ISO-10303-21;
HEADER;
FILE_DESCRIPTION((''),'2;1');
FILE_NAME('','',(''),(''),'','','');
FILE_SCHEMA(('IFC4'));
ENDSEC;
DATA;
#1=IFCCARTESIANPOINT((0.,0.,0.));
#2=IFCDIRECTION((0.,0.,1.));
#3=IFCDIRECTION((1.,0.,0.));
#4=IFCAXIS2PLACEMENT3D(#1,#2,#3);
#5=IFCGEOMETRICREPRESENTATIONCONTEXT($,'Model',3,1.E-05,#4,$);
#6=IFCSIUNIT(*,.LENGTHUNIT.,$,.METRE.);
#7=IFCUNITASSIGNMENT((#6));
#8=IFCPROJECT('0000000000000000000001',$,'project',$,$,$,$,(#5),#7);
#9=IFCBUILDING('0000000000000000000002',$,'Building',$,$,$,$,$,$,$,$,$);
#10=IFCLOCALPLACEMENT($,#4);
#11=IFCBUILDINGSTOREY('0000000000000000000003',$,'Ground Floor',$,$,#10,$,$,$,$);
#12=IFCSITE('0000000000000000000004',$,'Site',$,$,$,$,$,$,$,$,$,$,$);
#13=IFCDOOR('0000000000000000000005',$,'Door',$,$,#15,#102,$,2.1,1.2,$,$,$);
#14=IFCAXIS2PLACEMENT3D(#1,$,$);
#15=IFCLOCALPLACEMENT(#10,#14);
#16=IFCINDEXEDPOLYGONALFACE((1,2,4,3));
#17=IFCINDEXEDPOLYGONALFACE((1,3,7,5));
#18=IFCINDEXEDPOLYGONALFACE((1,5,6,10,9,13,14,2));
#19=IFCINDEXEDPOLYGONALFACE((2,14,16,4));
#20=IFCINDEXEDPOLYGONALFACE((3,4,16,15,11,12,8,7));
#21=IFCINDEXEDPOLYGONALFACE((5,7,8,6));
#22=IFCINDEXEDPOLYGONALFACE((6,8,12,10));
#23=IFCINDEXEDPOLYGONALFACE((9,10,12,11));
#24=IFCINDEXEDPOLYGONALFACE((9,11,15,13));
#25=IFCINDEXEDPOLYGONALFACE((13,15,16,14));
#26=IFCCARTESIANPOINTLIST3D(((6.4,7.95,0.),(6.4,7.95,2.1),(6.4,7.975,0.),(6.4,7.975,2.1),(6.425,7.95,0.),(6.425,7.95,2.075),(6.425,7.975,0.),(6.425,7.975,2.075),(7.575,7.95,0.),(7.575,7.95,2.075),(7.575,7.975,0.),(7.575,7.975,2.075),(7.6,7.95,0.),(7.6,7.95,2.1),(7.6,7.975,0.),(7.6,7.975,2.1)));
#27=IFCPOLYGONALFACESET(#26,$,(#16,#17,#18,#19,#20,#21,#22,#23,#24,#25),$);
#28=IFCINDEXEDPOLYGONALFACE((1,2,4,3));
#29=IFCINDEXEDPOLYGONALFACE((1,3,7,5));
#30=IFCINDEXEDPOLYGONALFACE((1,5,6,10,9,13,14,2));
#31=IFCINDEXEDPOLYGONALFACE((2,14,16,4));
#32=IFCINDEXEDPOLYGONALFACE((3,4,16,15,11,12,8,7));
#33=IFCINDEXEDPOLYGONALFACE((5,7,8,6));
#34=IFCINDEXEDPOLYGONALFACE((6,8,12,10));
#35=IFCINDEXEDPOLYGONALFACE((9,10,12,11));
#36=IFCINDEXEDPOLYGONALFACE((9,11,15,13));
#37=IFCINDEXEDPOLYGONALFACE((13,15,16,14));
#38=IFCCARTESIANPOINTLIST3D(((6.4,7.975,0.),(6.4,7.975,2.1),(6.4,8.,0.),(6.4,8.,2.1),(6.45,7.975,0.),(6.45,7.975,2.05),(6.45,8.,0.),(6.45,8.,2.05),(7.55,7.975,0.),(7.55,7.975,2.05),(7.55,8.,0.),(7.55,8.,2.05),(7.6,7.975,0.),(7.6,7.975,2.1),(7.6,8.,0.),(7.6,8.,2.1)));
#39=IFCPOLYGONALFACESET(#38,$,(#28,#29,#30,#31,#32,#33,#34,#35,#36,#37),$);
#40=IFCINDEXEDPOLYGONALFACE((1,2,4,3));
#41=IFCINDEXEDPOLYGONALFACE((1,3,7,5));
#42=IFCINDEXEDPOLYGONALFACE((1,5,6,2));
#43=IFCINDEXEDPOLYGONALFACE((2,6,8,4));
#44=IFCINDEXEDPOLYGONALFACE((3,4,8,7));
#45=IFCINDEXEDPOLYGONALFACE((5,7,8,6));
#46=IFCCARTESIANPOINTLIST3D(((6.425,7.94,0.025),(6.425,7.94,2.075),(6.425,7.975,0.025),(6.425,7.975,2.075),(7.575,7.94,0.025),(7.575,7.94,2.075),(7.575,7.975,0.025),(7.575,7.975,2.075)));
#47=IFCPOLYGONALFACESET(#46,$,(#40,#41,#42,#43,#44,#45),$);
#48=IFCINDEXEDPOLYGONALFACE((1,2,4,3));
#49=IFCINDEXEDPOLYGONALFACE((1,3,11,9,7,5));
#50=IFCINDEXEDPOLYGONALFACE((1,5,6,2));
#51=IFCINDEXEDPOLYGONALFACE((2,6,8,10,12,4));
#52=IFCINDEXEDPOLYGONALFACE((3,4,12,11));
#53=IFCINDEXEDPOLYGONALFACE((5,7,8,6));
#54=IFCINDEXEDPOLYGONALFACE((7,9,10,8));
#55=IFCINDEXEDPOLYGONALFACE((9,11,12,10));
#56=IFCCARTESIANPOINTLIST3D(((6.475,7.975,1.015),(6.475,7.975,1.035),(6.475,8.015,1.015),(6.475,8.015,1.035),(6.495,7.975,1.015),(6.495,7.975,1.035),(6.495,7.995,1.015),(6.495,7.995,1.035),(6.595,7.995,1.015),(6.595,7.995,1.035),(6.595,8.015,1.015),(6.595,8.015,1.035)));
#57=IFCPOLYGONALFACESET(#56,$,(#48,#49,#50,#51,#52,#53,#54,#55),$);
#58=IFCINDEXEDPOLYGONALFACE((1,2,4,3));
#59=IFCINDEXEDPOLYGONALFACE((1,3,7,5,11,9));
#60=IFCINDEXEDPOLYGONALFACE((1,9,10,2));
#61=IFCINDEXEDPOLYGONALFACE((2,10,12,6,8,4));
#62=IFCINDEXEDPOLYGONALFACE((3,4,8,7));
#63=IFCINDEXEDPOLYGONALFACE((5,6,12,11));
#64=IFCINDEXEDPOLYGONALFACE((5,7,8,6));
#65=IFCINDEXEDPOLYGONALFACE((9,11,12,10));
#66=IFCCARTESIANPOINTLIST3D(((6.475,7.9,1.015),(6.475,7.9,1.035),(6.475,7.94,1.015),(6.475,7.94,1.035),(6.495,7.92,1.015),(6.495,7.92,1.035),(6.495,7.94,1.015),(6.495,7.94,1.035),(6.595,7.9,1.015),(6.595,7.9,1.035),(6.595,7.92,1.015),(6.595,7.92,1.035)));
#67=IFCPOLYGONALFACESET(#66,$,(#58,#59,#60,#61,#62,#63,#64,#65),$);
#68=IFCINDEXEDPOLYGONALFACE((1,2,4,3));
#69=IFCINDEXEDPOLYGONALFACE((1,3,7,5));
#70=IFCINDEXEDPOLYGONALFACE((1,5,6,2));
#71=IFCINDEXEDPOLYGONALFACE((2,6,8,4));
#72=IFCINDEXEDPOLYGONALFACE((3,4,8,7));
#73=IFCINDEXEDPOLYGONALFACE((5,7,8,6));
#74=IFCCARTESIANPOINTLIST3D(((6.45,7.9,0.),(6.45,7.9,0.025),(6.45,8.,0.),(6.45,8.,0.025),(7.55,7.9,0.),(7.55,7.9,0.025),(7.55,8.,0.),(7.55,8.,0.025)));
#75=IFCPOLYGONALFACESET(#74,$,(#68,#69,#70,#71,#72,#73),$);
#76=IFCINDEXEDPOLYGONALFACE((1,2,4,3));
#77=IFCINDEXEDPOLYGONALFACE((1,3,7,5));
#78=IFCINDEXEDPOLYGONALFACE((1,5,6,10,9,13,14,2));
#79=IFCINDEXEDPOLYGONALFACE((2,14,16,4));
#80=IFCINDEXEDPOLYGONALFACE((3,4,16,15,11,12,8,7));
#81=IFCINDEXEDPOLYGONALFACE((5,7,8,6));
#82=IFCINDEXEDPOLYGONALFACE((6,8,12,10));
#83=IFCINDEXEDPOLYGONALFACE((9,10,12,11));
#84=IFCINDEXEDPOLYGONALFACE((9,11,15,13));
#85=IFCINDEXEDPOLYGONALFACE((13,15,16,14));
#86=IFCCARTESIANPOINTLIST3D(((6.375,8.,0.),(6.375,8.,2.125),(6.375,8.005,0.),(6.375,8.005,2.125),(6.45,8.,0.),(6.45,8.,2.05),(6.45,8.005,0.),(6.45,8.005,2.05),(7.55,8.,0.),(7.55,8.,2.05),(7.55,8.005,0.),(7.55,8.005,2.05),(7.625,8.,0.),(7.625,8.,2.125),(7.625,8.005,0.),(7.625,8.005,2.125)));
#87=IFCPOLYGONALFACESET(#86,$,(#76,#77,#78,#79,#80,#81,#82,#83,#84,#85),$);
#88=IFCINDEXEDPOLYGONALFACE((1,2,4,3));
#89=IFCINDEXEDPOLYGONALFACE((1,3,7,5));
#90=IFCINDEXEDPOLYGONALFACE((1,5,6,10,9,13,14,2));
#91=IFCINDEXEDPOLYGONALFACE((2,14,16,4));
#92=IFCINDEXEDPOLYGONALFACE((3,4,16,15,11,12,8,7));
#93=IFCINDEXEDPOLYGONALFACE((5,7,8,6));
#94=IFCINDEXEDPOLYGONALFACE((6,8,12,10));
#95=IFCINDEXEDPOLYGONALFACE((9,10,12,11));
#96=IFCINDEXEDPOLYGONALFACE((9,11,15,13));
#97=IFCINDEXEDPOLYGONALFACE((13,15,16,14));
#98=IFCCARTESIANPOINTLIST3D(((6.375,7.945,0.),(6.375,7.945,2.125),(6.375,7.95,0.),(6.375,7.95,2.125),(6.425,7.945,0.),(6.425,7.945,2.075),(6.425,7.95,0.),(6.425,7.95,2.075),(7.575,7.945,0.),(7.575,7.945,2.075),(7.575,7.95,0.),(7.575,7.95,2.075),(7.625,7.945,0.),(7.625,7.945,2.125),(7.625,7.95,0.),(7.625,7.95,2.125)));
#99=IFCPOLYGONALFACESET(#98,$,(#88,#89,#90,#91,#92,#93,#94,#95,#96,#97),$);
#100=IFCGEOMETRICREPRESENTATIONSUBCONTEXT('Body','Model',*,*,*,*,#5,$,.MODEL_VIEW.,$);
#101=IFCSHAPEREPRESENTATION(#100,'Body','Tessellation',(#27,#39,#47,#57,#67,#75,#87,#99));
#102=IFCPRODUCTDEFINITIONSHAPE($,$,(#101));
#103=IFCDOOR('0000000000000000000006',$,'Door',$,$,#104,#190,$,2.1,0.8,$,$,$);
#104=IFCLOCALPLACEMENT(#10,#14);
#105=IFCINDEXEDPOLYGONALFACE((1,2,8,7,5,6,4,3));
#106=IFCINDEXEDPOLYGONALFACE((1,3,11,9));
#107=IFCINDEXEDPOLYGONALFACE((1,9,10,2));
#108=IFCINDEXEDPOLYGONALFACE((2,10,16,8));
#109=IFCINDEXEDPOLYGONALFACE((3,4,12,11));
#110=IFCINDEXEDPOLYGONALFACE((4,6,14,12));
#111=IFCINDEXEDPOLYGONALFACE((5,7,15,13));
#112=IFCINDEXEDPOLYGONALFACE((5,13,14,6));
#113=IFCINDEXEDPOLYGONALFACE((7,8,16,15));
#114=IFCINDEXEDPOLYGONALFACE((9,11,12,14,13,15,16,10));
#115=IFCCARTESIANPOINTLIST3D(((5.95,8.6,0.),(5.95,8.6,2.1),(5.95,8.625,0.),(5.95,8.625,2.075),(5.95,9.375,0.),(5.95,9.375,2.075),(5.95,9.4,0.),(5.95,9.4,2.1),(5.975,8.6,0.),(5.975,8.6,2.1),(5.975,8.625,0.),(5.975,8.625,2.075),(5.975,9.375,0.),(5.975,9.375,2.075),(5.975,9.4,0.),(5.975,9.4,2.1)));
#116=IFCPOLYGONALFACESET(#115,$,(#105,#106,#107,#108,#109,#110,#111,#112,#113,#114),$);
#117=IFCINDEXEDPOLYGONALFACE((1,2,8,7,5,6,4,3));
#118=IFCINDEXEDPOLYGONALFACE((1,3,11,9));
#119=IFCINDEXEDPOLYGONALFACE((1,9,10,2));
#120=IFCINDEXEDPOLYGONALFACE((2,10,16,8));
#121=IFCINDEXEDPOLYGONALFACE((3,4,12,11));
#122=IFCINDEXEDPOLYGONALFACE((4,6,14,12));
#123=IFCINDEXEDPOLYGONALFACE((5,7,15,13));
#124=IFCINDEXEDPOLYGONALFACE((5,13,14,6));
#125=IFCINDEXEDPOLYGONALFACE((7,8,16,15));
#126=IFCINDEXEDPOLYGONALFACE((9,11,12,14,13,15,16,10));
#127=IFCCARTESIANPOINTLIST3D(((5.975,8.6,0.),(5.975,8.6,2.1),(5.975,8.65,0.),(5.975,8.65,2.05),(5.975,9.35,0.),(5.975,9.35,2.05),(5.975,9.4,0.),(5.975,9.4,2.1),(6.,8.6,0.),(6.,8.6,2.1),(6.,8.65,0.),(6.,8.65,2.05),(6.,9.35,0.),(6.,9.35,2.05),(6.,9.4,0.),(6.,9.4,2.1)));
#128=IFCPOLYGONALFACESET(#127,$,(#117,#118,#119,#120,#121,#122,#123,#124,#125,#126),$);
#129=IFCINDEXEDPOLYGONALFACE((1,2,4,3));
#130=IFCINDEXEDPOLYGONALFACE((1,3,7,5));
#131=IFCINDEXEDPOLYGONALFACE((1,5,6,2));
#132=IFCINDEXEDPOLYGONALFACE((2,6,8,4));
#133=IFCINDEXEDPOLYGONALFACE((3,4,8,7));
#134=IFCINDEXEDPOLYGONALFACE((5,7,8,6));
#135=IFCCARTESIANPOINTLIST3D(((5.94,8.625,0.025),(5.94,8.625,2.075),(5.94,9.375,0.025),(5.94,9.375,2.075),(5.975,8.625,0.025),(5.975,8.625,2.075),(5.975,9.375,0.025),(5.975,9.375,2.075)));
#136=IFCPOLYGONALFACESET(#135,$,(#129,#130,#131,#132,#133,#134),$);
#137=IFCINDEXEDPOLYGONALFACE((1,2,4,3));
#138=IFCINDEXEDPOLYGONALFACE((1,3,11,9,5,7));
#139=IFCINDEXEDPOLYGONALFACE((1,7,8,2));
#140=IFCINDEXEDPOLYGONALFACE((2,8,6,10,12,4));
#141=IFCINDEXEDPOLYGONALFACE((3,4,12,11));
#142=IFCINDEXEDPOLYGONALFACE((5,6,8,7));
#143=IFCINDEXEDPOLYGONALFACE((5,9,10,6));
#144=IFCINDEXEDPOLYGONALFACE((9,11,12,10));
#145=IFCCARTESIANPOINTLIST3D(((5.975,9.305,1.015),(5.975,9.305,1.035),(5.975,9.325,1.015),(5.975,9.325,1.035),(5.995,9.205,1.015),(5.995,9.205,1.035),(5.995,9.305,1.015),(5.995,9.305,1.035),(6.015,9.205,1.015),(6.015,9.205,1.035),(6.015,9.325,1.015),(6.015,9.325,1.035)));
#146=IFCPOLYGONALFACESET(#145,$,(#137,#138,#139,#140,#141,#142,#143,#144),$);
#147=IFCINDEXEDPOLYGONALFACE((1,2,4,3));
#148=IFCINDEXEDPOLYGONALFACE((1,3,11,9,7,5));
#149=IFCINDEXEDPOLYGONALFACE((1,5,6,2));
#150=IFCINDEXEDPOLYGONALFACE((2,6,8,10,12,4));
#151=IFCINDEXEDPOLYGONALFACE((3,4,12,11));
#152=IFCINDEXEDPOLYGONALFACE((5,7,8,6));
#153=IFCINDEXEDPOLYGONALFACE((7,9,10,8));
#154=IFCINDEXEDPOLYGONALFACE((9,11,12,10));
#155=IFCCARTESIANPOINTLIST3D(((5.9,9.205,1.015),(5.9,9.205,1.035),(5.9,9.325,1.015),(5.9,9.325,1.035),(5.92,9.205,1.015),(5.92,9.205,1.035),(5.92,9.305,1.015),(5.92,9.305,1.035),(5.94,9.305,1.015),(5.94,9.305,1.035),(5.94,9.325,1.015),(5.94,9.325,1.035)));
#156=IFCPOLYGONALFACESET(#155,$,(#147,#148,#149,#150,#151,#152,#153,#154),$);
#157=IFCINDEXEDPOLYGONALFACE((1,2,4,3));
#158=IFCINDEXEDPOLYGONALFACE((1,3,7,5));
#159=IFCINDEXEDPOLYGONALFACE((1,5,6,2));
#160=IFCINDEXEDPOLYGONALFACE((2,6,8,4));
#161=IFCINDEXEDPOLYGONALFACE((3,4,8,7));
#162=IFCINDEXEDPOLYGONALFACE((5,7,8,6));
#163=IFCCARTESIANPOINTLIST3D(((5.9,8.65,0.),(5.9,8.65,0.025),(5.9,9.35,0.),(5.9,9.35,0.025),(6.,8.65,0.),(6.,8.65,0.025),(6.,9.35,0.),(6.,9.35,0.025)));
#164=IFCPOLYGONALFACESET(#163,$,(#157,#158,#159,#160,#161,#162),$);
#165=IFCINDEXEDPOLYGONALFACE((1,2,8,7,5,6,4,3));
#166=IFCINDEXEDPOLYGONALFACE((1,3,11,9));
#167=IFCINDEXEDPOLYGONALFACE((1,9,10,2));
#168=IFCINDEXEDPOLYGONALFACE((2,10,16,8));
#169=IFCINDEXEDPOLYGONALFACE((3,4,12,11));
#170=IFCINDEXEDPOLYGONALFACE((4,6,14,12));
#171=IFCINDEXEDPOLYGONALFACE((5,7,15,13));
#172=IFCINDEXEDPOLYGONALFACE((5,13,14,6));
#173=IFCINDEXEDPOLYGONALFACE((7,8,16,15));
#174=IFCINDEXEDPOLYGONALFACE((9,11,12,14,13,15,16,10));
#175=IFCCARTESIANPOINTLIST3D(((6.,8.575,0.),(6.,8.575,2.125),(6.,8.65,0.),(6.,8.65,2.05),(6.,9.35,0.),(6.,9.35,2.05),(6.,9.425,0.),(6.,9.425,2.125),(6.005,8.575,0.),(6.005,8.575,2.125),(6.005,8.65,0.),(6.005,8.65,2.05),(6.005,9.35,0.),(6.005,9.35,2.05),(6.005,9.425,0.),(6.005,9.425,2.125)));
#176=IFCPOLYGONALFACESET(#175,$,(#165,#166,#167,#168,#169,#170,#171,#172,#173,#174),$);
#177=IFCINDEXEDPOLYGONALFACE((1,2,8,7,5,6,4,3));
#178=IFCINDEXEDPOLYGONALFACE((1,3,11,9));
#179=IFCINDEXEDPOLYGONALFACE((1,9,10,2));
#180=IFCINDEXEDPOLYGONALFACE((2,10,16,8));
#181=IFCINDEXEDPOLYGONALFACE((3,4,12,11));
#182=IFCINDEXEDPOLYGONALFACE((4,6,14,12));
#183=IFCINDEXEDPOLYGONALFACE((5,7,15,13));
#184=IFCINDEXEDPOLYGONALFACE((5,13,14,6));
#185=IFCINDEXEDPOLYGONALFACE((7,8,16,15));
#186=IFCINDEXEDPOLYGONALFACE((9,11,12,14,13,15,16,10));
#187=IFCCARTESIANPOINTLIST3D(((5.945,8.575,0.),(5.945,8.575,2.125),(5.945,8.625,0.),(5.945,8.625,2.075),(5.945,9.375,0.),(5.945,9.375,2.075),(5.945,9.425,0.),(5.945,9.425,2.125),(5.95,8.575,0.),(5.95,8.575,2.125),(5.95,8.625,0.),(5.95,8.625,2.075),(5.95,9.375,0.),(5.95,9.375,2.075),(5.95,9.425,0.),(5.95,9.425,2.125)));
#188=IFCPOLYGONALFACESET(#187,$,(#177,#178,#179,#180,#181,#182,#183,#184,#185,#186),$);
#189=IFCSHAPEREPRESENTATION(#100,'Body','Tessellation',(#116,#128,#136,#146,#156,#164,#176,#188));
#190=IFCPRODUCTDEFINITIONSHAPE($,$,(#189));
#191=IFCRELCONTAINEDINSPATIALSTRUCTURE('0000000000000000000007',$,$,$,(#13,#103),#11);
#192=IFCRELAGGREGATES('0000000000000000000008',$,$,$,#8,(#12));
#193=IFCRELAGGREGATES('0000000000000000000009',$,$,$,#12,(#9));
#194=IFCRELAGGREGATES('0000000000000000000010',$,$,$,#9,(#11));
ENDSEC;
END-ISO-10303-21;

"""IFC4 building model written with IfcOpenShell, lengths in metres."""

from ifc_helpers import new_model, si_unit, frame, origin_with_axes, place, context, subcontext, project, spatial, line, indexed_curve, outline, extrude, element, save


model = new_model("IFC4")

# Units and contexts
model_context = context("Model", 3, precision=1e-05, world=origin_with_axes())
body_context = subcontext(model_context, "Body", "Model", "MODEL_VIEW")
ifc_project = project(units=[si_unit("LENGTHUNIT", "METRE")], contexts=[model_context])

# Site, building, storey
site = spatial("IfcSite", under=ifc_project, Name="Site")
building = spatial("IfcBuilding", under=site, Name="Building")
storey_placement = place(None, origin_with_axes())
storey = spatial("IfcBuildingStorey", under=building, at=storey_placement, Name="Ground Floor")

# Doors
door_1_placement = place(storey_placement, frame((7.6, 8.0, 0.0), z_axis=(0.0, 0.0, 1.0), x_axis=(-1.0, 0.0, 0.0)))
element("IfcDoor", 1, at=door_1_placement, inside=storey, Name="Door", OverallHeight=2.1, OverallWidth=1.2, context=body_context, shape_type="SweptSolid", body=[
    extrude(outline(indexed_curve([(0.0, 0.0), (0.0, 2.1), (1.2, 2.1), (1.2, 0.0), (1.175, 0.0), (1.175, 2.075), (0.025, 2.075), (0.025, 0.0)], segments=[line(1, 2, 3, 4, 5, 6, 7, 8, 1)])), frame((0.0, 0.025, 0.0), z_axis=(0.0, -1.0, 0.0), x_axis=(1.0, 0.0, 0.0)), (0.0, 0.0, -1.0), 0.025),
    extrude(outline(indexed_curve([(0.0, 0.0), (0.0, 2.1), (1.2, 2.1), (1.2, 0.0), (1.15, 0.0), (1.15, 2.05), (0.05, 2.05), (0.05, 0.0)], segments=[line(1, 2, 3, 4, 5, 6, 7, 8, 1)])), frame((0.0, 0.0, 0.0), z_axis=(0.0, -1.0, 0.0), x_axis=(1.0, 0.0, 0.0)), (0.0, 0.0, -1.0), 0.025),
    extrude(outline(indexed_curve([(0.0, 0.0), (1.15, 0.0), (1.15, 0.035), (0.0, 0.035)], segments=[line(1, 2, 3, 4, 1)])), frame((0.025, 0.025, 0.025), z_axis=(0.0, 0.0, 1.0), x_axis=(1.0, 0.0, 0.0)), (0.0, 0.0, 1.0), 2.05),
    extrude(outline(indexed_curve([(0.0, 0.0), (0.0, -0.04), (-0.12, -0.04), (-0.12, -0.02), (-0.02, -0.02), (-0.02, 0.0)], segments=[line(1, 2, 3, 4, 5, 6, 1)])), frame((1.125, 0.025, 1.015), z_axis=(0.0, 0.0, 1.0), x_axis=(1.0, 0.0, 0.0)), (0.0, 0.0, 1.0), 0.02),
    extrude(outline(indexed_curve([(0.0, 0.0), (0.0, 0.04), (-0.12, 0.04), (-0.12, 0.02), (-0.02, 0.02), (-0.02, 0.0)], segments=[line(1, 2, 3, 4, 5, 6, 1)])), frame((1.125, 0.06, 1.015), z_axis=(0.0, 0.0, 1.0), x_axis=(1.0, 0.0, 0.0)), (0.0, 0.0, 1.0), 0.02),
    extrude(outline(indexed_curve([(0.0, 0.0), (1.1, 0.0), (1.1, 0.1), (0.0, 0.1)], segments=[line(1, 2, 3, 4, 1)])), frame((0.05, 0.0, 0.0), z_axis=(0.0, 0.0, 1.0), x_axis=(1.0, 0.0, 0.0)), (0.0, 0.0, 1.0), 0.025),
    extrude(outline(indexed_curve([(0.0, 0.0), (0.0, 2.125), (1.25, 2.125), (1.25, 0.0), (1.175, 0.0), (1.175, 2.05), (0.075, 2.05), (0.075, 0.0)], segments=[line(1, 2, 3, 4, 5, 6, 7, 8, 1)])), frame((-0.025, -0.005, 0.0), z_axis=(0.0, -1.0, 0.0), x_axis=(1.0, 0.0, 0.0)), (0.0, 0.0, -1.0), 0.005),
    extrude(outline(indexed_curve([(0.0, 0.0), (0.0, 2.125), (1.25, 2.125), (1.25, 0.0), (1.2, 0.0), (1.2, 2.075), (0.05, 2.075), (0.05, 0.0)], segments=[line(1, 2, 3, 4, 5, 6, 7, 8, 1)])), frame((-0.025, 0.05, 0.0), z_axis=(0.0, -1.0, 0.0), x_axis=(1.0, 0.0, 0.0)), (0.0, 0.0, -1.0), 0.005),
])
door_2_placement = place(storey_placement, frame((6.0, 8.6, 0.0), z_axis=(0.0, 0.0, 1.0), x_axis=(0.0, 1.0, 0.0)))
element("IfcDoor", 2, at=door_2_placement, inside=storey, Name="Door", OverallHeight=2.1, OverallWidth=0.8, context=body_context, shape_type="SweptSolid", body=[
    extrude(outline(indexed_curve([(0.0, 0.0), (0.0, 2.1), (0.8, 2.1), (0.8, 0.0), (0.775, 0.0), (0.775, 2.075), (0.025, 2.075), (0.025, 0.0)], segments=[line(1, 2, 3, 4, 5, 6, 7, 8, 1)])), frame((0.0, 0.025, 0.0), z_axis=(0.0, -1.0, 0.0), x_axis=(1.0, 0.0, 0.0)), (0.0, 0.0, -1.0), 0.025),
    extrude(outline(indexed_curve([(0.0, 0.0), (0.0, 2.1), (0.8, 2.1), (0.8, 0.0), (0.75, 0.0), (0.75, 2.05), (0.05, 2.05), (0.05, 0.0)], segments=[line(1, 2, 3, 4, 5, 6, 7, 8, 1)])), frame((0.0, 0.0, 0.0), z_axis=(0.0, -1.0, 0.0), x_axis=(1.0, 0.0, 0.0)), (0.0, 0.0, -1.0), 0.025),
    extrude(outline(indexed_curve([(0.0, 0.0), (0.75, 0.0), (0.75, 0.035), (0.0, 0.035)], segments=[line(1, 2, 3, 4, 1)])), frame((0.025, 0.025, 0.025), z_axis=(0.0, 0.0, 1.0), x_axis=(1.0, 0.0, 0.0)), (0.0, 0.0, 1.0), 2.05),
    extrude(outline(indexed_curve([(0.0, 0.0), (0.0, -0.04), (-0.12, -0.04), (-0.12, -0.02), (-0.02, -0.02), (-0.02, 0.0)], segments=[line(1, 2, 3, 4, 5, 6, 1)])), frame((0.725, 0.025, 1.015), z_axis=(0.0, 0.0, 1.0), x_axis=(1.0, 0.0, 0.0)), (0.0, 0.0, 1.0), 0.02),
    extrude(outline(indexed_curve([(0.0, 0.0), (0.0, 0.04), (-0.12, 0.04), (-0.12, 0.02), (-0.02, 0.02), (-0.02, 0.0)], segments=[line(1, 2, 3, 4, 5, 6, 1)])), frame((0.725, 0.06, 1.015), z_axis=(0.0, 0.0, 1.0), x_axis=(1.0, 0.0, 0.0)), (0.0, 0.0, 1.0), 0.02),
    extrude(outline(indexed_curve([(0.0, 0.0), (0.7, 0.0), (0.7, 0.1), (0.0, 0.1)], segments=[line(1, 2, 3, 4, 1)])), frame((0.05, 0.0, 0.0), z_axis=(0.0, 0.0, 1.0), x_axis=(1.0, 0.0, 0.0)), (0.0, 0.0, 1.0), 0.025),
    extrude(outline(indexed_curve([(0.0, 0.0), (0.0, 2.125), (0.85, 2.125), (0.85, 0.0), (0.775, 0.0), (0.775, 2.05), (0.075, 2.05), (0.075, 0.0)], segments=[line(1, 2, 3, 4, 5, 6, 7, 8, 1)])), frame((-0.025, -0.005, 0.0), z_axis=(0.0, -1.0, 0.0), x_axis=(1.0, 0.0, 0.0)), (0.0, 0.0, -1.0), 0.005),
    extrude(outline(indexed_curve([(0.0, 0.0), (0.0, 2.125), (0.85, 2.125), (0.85, 0.0), (0.8, 0.0), (0.8, 2.075), (0.05, 2.075), (0.05, 0.0)], segments=[line(1, 2, 3, 4, 5, 6, 7, 8, 1)])), frame((-0.025, 0.05, 0.0), z_axis=(0.0, -1.0, 0.0), x_axis=(1.0, 0.0, 0.0)), (0.0, 0.0, -1.0), 0.005),
])

save(model, "model.ifc")
